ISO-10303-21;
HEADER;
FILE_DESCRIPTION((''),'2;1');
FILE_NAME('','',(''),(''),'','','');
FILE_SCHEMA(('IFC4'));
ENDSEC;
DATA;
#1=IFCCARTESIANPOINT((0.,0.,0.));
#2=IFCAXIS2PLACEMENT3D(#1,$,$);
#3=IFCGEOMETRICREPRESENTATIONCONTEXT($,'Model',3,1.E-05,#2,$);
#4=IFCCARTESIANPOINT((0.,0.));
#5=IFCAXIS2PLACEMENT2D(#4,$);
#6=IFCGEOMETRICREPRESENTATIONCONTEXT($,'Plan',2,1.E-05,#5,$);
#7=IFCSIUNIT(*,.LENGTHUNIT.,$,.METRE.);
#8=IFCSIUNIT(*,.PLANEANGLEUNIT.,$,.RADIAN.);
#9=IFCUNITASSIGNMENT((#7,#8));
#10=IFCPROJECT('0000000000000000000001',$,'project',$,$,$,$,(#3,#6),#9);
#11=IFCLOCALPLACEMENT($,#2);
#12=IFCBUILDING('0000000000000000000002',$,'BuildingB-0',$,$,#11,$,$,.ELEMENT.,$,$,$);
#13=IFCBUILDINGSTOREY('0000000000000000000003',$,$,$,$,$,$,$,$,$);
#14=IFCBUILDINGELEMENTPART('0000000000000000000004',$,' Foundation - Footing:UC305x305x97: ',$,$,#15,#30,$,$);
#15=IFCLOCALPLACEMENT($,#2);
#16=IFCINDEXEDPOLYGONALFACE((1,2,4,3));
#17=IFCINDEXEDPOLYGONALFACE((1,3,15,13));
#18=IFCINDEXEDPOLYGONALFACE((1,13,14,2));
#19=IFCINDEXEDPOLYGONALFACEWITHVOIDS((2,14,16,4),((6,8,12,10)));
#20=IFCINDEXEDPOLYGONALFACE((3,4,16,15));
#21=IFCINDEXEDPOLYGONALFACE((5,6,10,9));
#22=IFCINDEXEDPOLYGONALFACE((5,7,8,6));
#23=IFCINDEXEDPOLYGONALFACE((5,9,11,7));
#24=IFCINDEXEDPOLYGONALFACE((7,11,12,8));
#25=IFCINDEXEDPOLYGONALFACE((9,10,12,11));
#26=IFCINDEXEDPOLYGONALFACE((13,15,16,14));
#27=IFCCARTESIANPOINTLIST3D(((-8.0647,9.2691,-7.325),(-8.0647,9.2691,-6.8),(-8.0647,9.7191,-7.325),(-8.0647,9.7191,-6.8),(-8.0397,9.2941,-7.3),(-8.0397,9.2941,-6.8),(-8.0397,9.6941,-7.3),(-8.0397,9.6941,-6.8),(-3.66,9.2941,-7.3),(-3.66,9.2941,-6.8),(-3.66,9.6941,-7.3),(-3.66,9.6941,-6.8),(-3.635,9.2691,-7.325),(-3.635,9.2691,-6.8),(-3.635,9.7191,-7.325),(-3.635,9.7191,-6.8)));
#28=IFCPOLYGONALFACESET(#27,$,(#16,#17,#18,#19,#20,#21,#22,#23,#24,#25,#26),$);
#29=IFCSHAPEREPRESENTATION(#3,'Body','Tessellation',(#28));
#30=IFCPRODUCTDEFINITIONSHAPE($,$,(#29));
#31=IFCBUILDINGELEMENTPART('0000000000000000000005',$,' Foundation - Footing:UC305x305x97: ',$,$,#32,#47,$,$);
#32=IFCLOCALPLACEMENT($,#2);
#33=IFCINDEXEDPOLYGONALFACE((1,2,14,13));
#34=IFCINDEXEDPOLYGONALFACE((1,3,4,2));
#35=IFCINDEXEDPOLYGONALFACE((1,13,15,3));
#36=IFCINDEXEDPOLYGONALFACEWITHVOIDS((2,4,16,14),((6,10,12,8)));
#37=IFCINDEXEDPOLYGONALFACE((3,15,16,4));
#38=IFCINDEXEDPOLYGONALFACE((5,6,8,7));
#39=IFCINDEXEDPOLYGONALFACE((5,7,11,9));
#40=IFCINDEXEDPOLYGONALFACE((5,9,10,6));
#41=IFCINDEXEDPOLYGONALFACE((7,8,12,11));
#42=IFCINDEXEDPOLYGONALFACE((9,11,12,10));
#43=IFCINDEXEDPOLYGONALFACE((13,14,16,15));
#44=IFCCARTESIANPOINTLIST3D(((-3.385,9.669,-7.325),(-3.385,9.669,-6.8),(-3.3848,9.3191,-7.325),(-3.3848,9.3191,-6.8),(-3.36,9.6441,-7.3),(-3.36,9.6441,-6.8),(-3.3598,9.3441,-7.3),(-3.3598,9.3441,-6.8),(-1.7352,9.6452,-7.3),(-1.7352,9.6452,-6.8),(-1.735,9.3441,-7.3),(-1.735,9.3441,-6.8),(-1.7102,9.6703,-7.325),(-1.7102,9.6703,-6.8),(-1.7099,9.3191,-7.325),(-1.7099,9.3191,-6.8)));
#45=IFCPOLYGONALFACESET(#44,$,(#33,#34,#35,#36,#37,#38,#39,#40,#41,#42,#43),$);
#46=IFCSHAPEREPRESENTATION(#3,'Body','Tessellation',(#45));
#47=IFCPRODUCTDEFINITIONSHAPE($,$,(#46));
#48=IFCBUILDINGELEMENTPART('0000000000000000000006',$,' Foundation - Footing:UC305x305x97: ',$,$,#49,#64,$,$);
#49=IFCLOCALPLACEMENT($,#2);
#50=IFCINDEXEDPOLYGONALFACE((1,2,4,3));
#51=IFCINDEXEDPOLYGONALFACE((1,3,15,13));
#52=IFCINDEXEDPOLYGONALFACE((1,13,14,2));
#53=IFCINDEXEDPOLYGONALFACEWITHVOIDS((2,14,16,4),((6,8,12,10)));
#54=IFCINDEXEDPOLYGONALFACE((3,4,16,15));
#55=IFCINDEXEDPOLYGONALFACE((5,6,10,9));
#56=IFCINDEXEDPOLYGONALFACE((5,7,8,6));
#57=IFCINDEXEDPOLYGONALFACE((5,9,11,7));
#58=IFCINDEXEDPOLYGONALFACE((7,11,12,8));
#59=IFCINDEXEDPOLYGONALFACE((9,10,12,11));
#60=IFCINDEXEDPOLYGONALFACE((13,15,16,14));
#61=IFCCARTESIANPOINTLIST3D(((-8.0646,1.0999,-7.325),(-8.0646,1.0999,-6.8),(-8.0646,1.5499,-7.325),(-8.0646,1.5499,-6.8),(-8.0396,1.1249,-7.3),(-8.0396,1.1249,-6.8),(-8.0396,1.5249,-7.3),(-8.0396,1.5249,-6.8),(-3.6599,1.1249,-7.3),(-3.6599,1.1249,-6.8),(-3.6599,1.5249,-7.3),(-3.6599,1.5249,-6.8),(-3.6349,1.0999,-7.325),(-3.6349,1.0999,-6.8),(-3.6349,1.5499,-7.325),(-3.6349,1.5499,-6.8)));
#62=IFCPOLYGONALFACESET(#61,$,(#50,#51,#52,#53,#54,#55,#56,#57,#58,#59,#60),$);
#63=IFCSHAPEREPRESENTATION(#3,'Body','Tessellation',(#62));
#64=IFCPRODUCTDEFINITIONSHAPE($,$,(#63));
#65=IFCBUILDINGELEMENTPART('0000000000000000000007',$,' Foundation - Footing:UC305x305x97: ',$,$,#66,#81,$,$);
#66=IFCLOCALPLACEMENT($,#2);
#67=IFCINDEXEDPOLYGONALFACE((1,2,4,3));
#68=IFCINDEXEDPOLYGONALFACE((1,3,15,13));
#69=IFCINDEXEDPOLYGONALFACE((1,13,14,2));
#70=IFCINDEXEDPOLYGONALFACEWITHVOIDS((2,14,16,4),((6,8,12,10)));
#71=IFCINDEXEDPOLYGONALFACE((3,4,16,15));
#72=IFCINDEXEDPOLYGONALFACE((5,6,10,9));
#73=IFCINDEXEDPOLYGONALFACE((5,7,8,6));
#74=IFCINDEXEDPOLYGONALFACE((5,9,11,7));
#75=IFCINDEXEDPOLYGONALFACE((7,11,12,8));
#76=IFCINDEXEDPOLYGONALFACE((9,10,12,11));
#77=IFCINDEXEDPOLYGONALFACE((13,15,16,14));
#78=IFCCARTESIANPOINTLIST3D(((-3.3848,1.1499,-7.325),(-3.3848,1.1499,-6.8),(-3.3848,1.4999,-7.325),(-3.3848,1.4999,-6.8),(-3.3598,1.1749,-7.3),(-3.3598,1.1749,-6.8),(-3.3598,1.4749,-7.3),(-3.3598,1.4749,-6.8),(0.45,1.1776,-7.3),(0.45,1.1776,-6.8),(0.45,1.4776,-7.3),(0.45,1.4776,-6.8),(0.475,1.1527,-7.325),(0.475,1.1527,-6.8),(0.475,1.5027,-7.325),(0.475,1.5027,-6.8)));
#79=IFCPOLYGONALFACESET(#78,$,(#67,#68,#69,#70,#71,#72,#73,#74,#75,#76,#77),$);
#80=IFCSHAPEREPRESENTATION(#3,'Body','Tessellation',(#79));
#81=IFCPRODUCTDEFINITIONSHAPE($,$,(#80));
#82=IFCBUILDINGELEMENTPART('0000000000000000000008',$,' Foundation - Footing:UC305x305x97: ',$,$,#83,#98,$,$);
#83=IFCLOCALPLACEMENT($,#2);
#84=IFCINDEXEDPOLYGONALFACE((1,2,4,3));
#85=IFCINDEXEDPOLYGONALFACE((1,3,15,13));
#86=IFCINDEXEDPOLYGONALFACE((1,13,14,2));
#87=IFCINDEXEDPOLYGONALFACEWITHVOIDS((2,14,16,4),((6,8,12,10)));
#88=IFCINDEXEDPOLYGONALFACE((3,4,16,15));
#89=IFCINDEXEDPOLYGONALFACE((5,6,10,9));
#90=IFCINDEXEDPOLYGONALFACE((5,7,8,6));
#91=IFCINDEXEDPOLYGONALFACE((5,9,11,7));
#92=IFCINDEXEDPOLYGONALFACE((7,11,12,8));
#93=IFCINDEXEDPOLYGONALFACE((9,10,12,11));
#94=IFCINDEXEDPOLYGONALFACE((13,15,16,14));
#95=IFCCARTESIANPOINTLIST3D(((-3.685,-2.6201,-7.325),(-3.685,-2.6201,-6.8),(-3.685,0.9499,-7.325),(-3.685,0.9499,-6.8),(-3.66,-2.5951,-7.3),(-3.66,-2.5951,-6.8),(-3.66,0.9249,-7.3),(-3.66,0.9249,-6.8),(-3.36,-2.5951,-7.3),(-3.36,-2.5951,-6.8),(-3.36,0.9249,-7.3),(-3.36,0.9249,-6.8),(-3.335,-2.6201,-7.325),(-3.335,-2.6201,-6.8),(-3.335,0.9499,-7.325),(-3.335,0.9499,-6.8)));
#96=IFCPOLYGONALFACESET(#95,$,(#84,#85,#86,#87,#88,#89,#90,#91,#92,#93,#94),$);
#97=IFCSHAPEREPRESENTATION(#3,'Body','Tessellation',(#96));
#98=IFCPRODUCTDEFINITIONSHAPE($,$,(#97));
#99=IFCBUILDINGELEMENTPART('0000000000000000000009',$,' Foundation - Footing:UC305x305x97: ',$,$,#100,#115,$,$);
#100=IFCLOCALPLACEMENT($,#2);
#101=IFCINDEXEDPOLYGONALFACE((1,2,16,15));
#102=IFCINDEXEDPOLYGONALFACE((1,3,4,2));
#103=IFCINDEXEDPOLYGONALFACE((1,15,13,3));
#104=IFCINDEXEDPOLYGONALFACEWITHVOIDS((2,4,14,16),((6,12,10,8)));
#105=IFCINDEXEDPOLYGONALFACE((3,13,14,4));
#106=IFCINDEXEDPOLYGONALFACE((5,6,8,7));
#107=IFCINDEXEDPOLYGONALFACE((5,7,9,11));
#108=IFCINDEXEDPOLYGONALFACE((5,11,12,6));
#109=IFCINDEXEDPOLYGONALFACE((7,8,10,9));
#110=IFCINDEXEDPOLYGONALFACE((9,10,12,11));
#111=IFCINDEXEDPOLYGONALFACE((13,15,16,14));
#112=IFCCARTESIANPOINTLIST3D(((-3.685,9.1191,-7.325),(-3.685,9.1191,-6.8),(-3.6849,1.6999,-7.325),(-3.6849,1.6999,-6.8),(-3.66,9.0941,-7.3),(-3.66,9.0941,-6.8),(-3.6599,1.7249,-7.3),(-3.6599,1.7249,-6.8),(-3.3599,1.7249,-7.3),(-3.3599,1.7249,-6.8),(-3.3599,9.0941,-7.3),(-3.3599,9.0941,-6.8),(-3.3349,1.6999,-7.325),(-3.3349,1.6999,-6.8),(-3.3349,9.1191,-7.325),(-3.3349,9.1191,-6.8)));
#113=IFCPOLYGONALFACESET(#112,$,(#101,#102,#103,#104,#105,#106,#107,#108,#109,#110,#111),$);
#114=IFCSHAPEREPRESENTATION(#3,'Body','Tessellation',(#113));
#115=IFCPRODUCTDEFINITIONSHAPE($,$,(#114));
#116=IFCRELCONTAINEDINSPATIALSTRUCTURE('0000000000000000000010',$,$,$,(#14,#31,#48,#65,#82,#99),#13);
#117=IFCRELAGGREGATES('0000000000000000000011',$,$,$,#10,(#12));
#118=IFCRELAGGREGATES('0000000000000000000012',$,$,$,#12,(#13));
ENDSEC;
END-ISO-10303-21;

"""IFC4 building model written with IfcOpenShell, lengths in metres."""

from ifc_helpers import new_model, si_unit, origin, origin_2d, place, context, project, spatial, polyline, outline, extrude, element, save


model = new_model("IFC4")

# Units and contexts
model_context = context("Model", 3, precision=1e-05, world=origin())
plan_context = context("Plan", 2, precision=1e-05, world=origin_2d())
ifc_project = project(units=[si_unit("LENGTHUNIT", "METRE"), si_unit("PLANEANGLEUNIT", "RADIAN")], contexts=[model_context, plan_context])

# Building, storey
building_placement = place(None, origin())
building = spatial("IfcBuilding", under=ifc_project, at=building_placement, Name="BuildingB-0", CompositionType="ELEMENT")
storey = spatial("IfcBuildingStorey", under=building)

# Building element parts, openings
building_element_part_1 = element("IfcBuildingElementPart", 1, inside=storey, Name=" Foundation - Footing:UC305x305x97: ", context=model_context, shape_type="SweptSolid", body=[
    extrude(outline(polyline([(-8.0647, 9.7191, -7.325), (-8.0647, 9.2691, -7.325), (-3.635, 9.2691, -7.325), (-3.635, 9.7191, -7.325), (-8.0647, 9.7191, -7.325)])), None, (0.0, 0.0, 1.0), 0.525),
])
element("IfcOpeningElement", 2, inside=storey, cuts=building_element_part_1, context=model_context, shape_type="SweptSolid", body=[
    extrude(outline(polyline([(-8.0397, 9.6941, -7.3), (-8.0397, 9.2941, -7.3), (-3.66, 9.2941, -7.3), (-3.66, 9.6941, -7.3), (-8.0397, 9.6941, -7.3)])), None, (0.0, 0.0, 1.0), 0.5),
])
building_element_part_2 = element("IfcBuildingElementPart", 3, inside=storey, Name=" Foundation - Footing:UC305x305x97: ", context=model_context, shape_type="SweptSolid", body=[
    extrude(outline(polyline([(-3.3848, 9.3191, -7.325), (-1.7099, 9.3191, -7.325), (-1.7102, 9.6703, -7.325), (-3.385, 9.669, -7.325), (-3.3848, 9.3191, -7.325)])), None, (0.0, 0.0, 1.0), 0.525),
])
element("IfcOpeningElement", 4, inside=storey, cuts=building_element_part_2, context=model_context, shape_type="SweptSolid", body=[
    extrude(outline(polyline([(-3.3598, 9.3441, -7.3), (-1.735, 9.3441, -7.3), (-1.7352, 9.6452, -7.3), (-3.36, 9.6441, -7.3), (-3.3598, 9.3441, -7.3)])), None, (0.0, 0.0, 1.0), 0.5),
])
building_element_part_3 = element("IfcBuildingElementPart", 5, inside=storey, Name=" Foundation - Footing:UC305x305x97: ", context=model_context, shape_type="SweptSolid", body=[
    extrude(outline(polyline([(-8.0646, 1.0999, -7.325), (-8.0646, 1.5499, -7.325), (-3.6349, 1.5499, -7.325), (-3.6349, 1.0999, -7.325), (-8.0646, 1.0999, -7.325)])), None, (0.0, 0.0, 1.0), 0.525),
])
element("IfcOpeningElement", 6, inside=storey, cuts=building_element_part_3, context=model_context, shape_type="SweptSolid", body=[
    extrude(outline(polyline([(-8.0396, 1.1249, -7.3), (-8.0396, 1.5249, -7.3), (-3.6599, 1.5249, -7.3), (-3.6599, 1.1249, -7.3), (-8.0396, 1.1249, -7.3)])), None, (0.0, 0.0, 1.0), 0.5),
])
building_element_part_4 = element("IfcBuildingElementPart", 7, inside=storey, Name=" Foundation - Footing:UC305x305x97: ", context=model_context, shape_type="SweptSolid", body=[
    extrude(outline(polyline([(-3.3848, 1.1499, -7.325), (-3.3848, 1.4999, -7.325), (0.475, 1.5027, -7.325), (0.475, 1.1527, -7.325), (-3.3848, 1.1499, -7.325)])), None, (0.0, 0.0, 1.0), 0.525),
])
element("IfcOpeningElement", 8, inside=storey, cuts=building_element_part_4, context=model_context, shape_type="SweptSolid", body=[
    extrude(outline(polyline([(-3.3598, 1.1749, -7.3), (-3.3598, 1.4749, -7.3), (0.45, 1.4776, -7.3), (0.45, 1.1776, -7.3), (-3.3598, 1.1749, -7.3)])), None, (0.0, 0.0, 1.0), 0.5),
])
building_element_part_5 = element("IfcBuildingElementPart", 9, inside=storey, Name=" Foundation - Footing:UC305x305x97: ", context=model_context, shape_type="SweptSolid", body=[
    extrude(outline(polyline([(-3.685, -2.6201, -7.325), (-3.335, -2.6201, -7.325), (-3.335, 0.9499, -7.325), (-3.685, 0.9499, -7.325), (-3.685, -2.6201, -7.325)])), None, (0.0, 0.0, 1.0), 0.525),
])
element("IfcOpeningElement", 10, inside=storey, cuts=building_element_part_5, context=model_context, shape_type="SweptSolid", body=[
    extrude(outline(polyline([(-3.66, -2.5951, -7.3), (-3.36, -2.5951, -7.3), (-3.36, 0.9249, -7.3), (-3.66, 0.9249, -7.3), (-3.66, -2.5951, -7.3)])), None, (0.0, 0.0, 1.0), 0.5),
])
building_element_part_6 = element("IfcBuildingElementPart", 11, inside=storey, Name=" Foundation - Footing:UC305x305x97: ", context=model_context, shape_type="SweptSolid", body=[
    extrude(outline(polyline([(-3.6849, 1.6999, -7.325), (-3.3349, 1.6999, -7.325), (-3.3349, 9.1191, -7.325), (-3.685, 9.1191, -7.325), (-3.6849, 1.6999, -7.325)])), None, (0.0, 0.0, 1.0), 0.525),
])
element("IfcOpeningElement", 12, inside=storey, cuts=building_element_part_6, context=model_context, shape_type="SweptSolid", body=[
    extrude(outline(polyline([(-3.6599, 1.7249, -7.3), (-3.3599, 1.7249, -7.3), (-3.3599, 9.0941, -7.3), (-3.66, 9.0941, -7.3), (-3.6599, 1.7249, -7.3)])), None, (0.0, 0.0, 1.0), 0.5),
])

save(model, "model.ifc")
